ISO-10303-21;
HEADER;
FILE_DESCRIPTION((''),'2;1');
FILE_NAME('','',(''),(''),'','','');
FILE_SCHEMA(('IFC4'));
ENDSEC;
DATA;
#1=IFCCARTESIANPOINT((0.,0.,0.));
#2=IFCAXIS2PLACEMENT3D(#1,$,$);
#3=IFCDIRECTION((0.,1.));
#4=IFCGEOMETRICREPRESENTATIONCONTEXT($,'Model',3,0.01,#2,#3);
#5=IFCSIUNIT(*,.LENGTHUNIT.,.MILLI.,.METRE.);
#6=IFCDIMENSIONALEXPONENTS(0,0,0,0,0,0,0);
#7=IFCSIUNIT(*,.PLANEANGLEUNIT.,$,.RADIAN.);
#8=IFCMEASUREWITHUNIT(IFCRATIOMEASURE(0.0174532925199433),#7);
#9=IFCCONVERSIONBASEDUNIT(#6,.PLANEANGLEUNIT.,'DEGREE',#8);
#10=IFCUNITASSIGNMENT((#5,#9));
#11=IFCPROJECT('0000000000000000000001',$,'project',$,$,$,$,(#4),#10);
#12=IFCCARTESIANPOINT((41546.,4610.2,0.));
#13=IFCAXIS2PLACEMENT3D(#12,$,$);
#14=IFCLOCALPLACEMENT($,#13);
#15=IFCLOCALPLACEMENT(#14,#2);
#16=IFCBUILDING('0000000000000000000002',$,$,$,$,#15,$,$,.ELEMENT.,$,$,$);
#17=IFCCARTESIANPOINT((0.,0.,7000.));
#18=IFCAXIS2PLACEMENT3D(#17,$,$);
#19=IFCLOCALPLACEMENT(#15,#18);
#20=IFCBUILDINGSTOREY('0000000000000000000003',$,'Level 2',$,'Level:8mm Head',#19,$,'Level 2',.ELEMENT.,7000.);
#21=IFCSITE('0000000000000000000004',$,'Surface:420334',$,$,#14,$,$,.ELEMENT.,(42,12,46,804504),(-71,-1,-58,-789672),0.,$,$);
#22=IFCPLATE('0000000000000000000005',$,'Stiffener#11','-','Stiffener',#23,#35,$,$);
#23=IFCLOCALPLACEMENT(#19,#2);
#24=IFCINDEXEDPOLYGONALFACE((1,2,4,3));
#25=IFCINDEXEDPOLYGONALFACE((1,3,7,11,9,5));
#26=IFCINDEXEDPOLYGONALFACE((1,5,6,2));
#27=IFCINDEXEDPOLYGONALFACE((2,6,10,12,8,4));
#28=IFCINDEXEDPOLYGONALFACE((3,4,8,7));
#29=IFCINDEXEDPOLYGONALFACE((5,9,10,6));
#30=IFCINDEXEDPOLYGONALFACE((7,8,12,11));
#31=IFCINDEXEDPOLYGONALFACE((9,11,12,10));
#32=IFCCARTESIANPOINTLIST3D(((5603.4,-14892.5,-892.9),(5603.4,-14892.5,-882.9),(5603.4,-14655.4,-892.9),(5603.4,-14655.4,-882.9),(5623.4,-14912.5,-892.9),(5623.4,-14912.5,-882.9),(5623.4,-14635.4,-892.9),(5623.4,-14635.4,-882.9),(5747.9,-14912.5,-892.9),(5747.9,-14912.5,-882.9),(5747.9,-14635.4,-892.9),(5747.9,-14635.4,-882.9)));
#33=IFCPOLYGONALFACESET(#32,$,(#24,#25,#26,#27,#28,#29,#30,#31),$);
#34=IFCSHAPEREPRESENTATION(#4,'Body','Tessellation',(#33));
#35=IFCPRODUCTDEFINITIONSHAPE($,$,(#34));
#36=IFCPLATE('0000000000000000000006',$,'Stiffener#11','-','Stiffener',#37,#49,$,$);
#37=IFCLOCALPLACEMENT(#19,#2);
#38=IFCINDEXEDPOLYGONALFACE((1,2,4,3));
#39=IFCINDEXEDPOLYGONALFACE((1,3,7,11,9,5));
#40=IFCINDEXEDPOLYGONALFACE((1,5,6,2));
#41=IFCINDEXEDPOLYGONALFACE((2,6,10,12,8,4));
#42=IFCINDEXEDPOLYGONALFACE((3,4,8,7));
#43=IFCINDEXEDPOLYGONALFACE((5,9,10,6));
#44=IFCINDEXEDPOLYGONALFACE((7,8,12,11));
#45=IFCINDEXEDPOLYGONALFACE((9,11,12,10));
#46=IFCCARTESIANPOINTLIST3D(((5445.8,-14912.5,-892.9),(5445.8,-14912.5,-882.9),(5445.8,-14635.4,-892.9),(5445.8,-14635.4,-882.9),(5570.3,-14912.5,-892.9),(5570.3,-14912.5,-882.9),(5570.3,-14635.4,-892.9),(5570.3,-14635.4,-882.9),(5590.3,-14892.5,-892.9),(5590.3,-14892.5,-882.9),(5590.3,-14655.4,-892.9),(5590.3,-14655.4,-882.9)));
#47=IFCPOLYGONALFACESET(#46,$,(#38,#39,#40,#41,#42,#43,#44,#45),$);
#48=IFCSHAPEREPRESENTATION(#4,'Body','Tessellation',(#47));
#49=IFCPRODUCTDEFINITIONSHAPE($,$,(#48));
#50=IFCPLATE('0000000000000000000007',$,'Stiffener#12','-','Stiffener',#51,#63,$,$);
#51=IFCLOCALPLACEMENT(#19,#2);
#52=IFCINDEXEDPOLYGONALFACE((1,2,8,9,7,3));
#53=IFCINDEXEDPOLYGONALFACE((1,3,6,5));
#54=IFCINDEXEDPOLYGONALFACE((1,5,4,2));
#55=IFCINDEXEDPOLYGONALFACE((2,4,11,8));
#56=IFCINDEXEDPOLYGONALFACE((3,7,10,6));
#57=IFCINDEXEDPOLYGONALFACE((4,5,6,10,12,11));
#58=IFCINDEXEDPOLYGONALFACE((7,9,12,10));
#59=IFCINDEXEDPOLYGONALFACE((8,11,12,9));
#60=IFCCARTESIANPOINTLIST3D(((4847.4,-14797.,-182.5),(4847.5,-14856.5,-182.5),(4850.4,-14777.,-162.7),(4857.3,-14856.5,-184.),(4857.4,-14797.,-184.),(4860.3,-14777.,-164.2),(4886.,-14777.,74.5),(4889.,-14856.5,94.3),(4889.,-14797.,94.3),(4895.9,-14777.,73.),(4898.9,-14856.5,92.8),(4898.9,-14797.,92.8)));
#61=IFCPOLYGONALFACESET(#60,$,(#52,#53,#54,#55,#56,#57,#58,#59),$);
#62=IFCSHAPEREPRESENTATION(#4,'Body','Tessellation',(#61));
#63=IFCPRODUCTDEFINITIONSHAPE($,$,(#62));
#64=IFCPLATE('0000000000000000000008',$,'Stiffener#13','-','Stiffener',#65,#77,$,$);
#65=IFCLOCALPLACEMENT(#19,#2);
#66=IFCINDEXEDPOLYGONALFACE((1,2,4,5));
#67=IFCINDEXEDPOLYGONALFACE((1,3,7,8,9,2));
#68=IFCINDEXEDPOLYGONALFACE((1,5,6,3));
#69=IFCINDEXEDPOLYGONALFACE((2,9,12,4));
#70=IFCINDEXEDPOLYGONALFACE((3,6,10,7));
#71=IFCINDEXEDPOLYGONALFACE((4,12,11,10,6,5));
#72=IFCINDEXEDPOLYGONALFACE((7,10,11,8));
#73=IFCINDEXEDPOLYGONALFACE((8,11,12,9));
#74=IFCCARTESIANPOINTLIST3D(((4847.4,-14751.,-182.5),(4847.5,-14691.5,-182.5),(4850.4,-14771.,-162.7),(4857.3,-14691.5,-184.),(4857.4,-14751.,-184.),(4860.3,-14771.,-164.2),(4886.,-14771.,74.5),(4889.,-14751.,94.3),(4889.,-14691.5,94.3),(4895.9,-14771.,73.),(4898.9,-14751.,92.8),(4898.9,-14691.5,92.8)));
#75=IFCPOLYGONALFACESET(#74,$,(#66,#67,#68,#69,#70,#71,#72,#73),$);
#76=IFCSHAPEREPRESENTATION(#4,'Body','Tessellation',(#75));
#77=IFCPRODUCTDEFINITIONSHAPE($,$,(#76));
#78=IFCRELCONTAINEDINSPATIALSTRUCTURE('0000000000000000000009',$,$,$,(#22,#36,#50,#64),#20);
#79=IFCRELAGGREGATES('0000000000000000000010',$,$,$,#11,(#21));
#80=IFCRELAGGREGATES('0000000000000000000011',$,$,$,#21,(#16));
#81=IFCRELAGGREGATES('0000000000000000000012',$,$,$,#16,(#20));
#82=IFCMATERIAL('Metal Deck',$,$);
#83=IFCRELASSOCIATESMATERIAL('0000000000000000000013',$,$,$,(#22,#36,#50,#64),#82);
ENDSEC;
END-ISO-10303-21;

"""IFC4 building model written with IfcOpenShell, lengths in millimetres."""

from ifc_helpers import new_model, entity, si_unit, converted_unit, direction, frame, origin, origin_with_axes, place, context, project, spatial, polyline, outline, extrude, material, element, save


model = new_model("IFC4")

# Units and contexts
model_context = context("Model", 3, precision=0.01, world=origin(), true_north=direction((0.0, 1.0)))
ifc_project = project(units=[si_unit("LENGTHUNIT", "METRE", prefix="MILLI"), converted_unit("PLANEANGLEUNIT", "DEGREE", entity("IfcRatioMeasure", 0.0174532925199433), si_unit("PLANEANGLEUNIT", "RADIAN"), dimensions=[0, 0, 0, 0, 0, 0, 0])], contexts=[model_context])

# Site, building, storey
site_placement = place(None, frame((41546.0, 4610.2, 0.0)))
site = spatial("IfcSite", under=ifc_project, at=site_placement, Name="Surface:420334", CompositionType="ELEMENT", RefLatitude=(42, 12, 46, 804504), RefLongitude=(-71, -1, -58, -789672), RefElevation=0.0)
building_placement = place(site_placement, origin())
building = spatial("IfcBuilding", under=site, at=building_placement, CompositionType="ELEMENT")
storey_placement = place(building_placement, frame((0.0, 0.0, 7000.0)))
storey = spatial("IfcBuildingStorey", under=building, at=storey_placement, Name="Level 2", ObjectType="Level:8mm Head", LongName="Level 2", CompositionType="ELEMENT", Elevation=7000.0)

# Plates, openings
ifc_material = material(Name="Metal Deck")
plate_1_placement = place(storey_placement, frame((5603.4, -14912.5, -882.9), z_axis=(0.0, 0.0, -1.0), x_axis=(0.0, 1.0, 0.0)))
plate_1 = element("IfcPlate", 1, at=plate_1_placement, inside=storey, material=ifc_material, Name="Stiffener#11", Description="-", ObjectType="Stiffener", context=model_context, shape_type="SweptSolid", body=[
    extrude(outline(polyline([(0.0, 0.0), (277.1, 0.0), (277.1, 144.5), (0.0, 144.5), (0.0, 0.0)])), origin_with_axes(), (0.0, 0.0, 1.0), 10.0),
])
opening_1_placement = place(plate_1_placement, frame((0.0, 0.0, 0.0), z_axis=(0.0, 0.0, 1.0), x_axis=(1.0, 0.0, 0.0)))
element("IfcOpeningElement", 2, at=opening_1_placement, cuts=plate_1, ObjectType="Opening", context=model_context, shape_type="SweptSolid", body=[
    extrude(outline(polyline([(277.1, 0.0), (277.1, 20.0), (257.1, 0.0), (277.1, 0.0)])), origin(), (0.0, 0.0, 1.0), 10.0),
])
opening_2_placement = place(plate_1_placement, frame((0.0, 0.0, 0.0), z_axis=(0.0, 0.0, 1.0), x_axis=(1.0, 0.0, 0.0)))
element("IfcOpeningElement", 3, at=opening_2_placement, cuts=plate_1, ObjectType="Opening", context=model_context, shape_type="SweptSolid", body=[
    extrude(outline(polyline([(0.0, 0.0), (20.0, 0.0), (0.0, 20.0), (0.0, 0.0)])), origin(), (0.0, 0.0, 1.0), 10.0),
])
plate_2_placement = place(storey_placement, frame((5445.8, -14912.5, -882.9), z_axis=(0.0, 0.0, -1.0), x_axis=(0.0, 1.0, 0.0)))
plate_2 = element("IfcPlate", 4, at=plate_2_placement, inside=storey, material=ifc_material, Name="Stiffener#11", Description="-", ObjectType="Stiffener", context=model_context, shape_type="SweptSolid", body=[
    extrude(outline(polyline([(0.0, 0.0), (277.1, 0.0), (277.1, 144.5), (0.0, 144.5), (0.0, 0.0)])), origin_with_axes(), (0.0, 0.0, 1.0), 10.0),
])
opening_3_placement = place(plate_2_placement, frame((0.0, 0.0, 0.0), z_axis=(0.0, 0.0, 1.0), x_axis=(1.0, 0.0, 0.0)))
element("IfcOpeningElement", 5, at=opening_3_placement, cuts=plate_2, ObjectType="Opening", context=model_context, shape_type="SweptSolid", body=[
    extrude(outline(polyline([(277.1, 144.5), (257.1, 144.5), (277.1, 124.5), (277.1, 144.5)])), origin(), (0.0, 0.0, 1.0), 10.0),
])
opening_4_placement = place(plate_2_placement, frame((0.0, 0.0, 0.0), z_axis=(0.0, 0.0, 1.0), x_axis=(1.0, 0.0, 0.0)))
element("IfcOpeningElement", 6, at=opening_4_placement, cuts=plate_2, ObjectType="Opening", context=model_context, shape_type="SweptSolid", body=[
    extrude(outline(polyline([(0.0, 144.5), (0.0, 124.5), (20.0, 144.5), (0.0, 144.5)])), origin(), (0.0, 0.0, 1.0), 10.0),
])
plate_3_placement = place(storey_placement, frame((4857.3, -14777.0, -184.0), z_axis=(-0.988936, 0.0, 0.14834), x_axis=(0.0, -1.0, 0.0)))
plate_3 = element("IfcPlate", 7, at=plate_3_placement, inside=storey, material=ifc_material, Name="Stiffener#12", Description="-", ObjectType="Stiffener", context=model_context, shape_type="SweptSolid", body=[
    extrude(outline(polyline([(0.0, 0.0), (79.5, 0.0), (79.5, 279.8), (0.0, 279.8), (0.0, 0.0)])), origin_with_axes(), (0.0, 0.0, 1.0), 10.0),
])
opening_5_placement = place(plate_3_placement, frame((0.0, 0.0, 0.0), z_axis=(0.0, 0.0, 1.0), x_axis=(1.0, 0.0, 0.0)))
element("IfcOpeningElement", 8, at=opening_5_placement, cuts=plate_3, ObjectType="Opening", context=model_context, shape_type="SweptSolid", body=[
    extrude(outline(polyline([(0.0, 279.8), (0.0, 259.8), (20.0, 279.8), (0.0, 279.8)])), origin(), (0.0, 0.0, 1.0), 10.0),
])
opening_6_placement = place(plate_3_placement, frame((0.0, 0.0, 0.0), z_axis=(0.0, 0.0, 1.0), x_axis=(1.0, 0.0, 0.0)))
element("IfcOpeningElement", 9, at=opening_6_placement, cuts=plate_3, ObjectType="Opening", context=model_context, shape_type="SweptSolid", body=[
    extrude(outline(polyline([(0.0, 0.0), (20.0, 0.0), (0.0, 20.0), (0.0, 0.0)])), origin(), (0.0, 0.0, 1.0), 10.0),
])
plate_4_placement = place(storey_placement, frame((4857.3, -14691.5, -184.0), z_axis=(-0.988936, 0.0, 0.14834), x_axis=(0.0, -1.0, 0.0)))
plate_4 = element("IfcPlate", 10, at=plate_4_placement, inside=storey, material=ifc_material, Name="Stiffener#13", Description="-", ObjectType="Stiffener", context=model_context, shape_type="SweptSolid", body=[
    extrude(outline(polyline([(0.0, 0.0), (79.5, 0.0), (79.5, 279.8), (0.0, 279.8), (0.0, 0.0)])), origin_with_axes(), (0.0, 0.0, 1.0), 10.0),
])
opening_7_placement = place(plate_4_placement, frame((0.0, 0.0, 0.0), z_axis=(0.0, 0.0, 1.0), x_axis=(1.0, 0.0, 0.0)))
element("IfcOpeningElement", 11, at=opening_7_placement, cuts=plate_4, ObjectType="Opening", context=model_context, shape_type="SweptSolid", body=[
    extrude(outline(polyline([(79.5, 279.8), (59.5, 279.8), (79.5, 259.8), (79.5, 279.8)])), origin(), (0.0, 0.0, 1.0), 10.0),
])
opening_8_placement = place(plate_4_placement, frame((0.0, 0.0, 0.0), z_axis=(0.0, 0.0, 1.0), x_axis=(1.0, 0.0, 0.0)))
element("IfcOpeningElement", 12, at=opening_8_placement, cuts=plate_4, ObjectType="Opening", context=model_context, shape_type="SweptSolid", body=[
    extrude(outline(polyline([(79.5, 0.0), (79.5, 20.0), (59.5, 0.0), (79.5, 0.0)])), origin(), (0.0, 0.0, 1.0), 10.0),
])

save(model, "model.ifc")
